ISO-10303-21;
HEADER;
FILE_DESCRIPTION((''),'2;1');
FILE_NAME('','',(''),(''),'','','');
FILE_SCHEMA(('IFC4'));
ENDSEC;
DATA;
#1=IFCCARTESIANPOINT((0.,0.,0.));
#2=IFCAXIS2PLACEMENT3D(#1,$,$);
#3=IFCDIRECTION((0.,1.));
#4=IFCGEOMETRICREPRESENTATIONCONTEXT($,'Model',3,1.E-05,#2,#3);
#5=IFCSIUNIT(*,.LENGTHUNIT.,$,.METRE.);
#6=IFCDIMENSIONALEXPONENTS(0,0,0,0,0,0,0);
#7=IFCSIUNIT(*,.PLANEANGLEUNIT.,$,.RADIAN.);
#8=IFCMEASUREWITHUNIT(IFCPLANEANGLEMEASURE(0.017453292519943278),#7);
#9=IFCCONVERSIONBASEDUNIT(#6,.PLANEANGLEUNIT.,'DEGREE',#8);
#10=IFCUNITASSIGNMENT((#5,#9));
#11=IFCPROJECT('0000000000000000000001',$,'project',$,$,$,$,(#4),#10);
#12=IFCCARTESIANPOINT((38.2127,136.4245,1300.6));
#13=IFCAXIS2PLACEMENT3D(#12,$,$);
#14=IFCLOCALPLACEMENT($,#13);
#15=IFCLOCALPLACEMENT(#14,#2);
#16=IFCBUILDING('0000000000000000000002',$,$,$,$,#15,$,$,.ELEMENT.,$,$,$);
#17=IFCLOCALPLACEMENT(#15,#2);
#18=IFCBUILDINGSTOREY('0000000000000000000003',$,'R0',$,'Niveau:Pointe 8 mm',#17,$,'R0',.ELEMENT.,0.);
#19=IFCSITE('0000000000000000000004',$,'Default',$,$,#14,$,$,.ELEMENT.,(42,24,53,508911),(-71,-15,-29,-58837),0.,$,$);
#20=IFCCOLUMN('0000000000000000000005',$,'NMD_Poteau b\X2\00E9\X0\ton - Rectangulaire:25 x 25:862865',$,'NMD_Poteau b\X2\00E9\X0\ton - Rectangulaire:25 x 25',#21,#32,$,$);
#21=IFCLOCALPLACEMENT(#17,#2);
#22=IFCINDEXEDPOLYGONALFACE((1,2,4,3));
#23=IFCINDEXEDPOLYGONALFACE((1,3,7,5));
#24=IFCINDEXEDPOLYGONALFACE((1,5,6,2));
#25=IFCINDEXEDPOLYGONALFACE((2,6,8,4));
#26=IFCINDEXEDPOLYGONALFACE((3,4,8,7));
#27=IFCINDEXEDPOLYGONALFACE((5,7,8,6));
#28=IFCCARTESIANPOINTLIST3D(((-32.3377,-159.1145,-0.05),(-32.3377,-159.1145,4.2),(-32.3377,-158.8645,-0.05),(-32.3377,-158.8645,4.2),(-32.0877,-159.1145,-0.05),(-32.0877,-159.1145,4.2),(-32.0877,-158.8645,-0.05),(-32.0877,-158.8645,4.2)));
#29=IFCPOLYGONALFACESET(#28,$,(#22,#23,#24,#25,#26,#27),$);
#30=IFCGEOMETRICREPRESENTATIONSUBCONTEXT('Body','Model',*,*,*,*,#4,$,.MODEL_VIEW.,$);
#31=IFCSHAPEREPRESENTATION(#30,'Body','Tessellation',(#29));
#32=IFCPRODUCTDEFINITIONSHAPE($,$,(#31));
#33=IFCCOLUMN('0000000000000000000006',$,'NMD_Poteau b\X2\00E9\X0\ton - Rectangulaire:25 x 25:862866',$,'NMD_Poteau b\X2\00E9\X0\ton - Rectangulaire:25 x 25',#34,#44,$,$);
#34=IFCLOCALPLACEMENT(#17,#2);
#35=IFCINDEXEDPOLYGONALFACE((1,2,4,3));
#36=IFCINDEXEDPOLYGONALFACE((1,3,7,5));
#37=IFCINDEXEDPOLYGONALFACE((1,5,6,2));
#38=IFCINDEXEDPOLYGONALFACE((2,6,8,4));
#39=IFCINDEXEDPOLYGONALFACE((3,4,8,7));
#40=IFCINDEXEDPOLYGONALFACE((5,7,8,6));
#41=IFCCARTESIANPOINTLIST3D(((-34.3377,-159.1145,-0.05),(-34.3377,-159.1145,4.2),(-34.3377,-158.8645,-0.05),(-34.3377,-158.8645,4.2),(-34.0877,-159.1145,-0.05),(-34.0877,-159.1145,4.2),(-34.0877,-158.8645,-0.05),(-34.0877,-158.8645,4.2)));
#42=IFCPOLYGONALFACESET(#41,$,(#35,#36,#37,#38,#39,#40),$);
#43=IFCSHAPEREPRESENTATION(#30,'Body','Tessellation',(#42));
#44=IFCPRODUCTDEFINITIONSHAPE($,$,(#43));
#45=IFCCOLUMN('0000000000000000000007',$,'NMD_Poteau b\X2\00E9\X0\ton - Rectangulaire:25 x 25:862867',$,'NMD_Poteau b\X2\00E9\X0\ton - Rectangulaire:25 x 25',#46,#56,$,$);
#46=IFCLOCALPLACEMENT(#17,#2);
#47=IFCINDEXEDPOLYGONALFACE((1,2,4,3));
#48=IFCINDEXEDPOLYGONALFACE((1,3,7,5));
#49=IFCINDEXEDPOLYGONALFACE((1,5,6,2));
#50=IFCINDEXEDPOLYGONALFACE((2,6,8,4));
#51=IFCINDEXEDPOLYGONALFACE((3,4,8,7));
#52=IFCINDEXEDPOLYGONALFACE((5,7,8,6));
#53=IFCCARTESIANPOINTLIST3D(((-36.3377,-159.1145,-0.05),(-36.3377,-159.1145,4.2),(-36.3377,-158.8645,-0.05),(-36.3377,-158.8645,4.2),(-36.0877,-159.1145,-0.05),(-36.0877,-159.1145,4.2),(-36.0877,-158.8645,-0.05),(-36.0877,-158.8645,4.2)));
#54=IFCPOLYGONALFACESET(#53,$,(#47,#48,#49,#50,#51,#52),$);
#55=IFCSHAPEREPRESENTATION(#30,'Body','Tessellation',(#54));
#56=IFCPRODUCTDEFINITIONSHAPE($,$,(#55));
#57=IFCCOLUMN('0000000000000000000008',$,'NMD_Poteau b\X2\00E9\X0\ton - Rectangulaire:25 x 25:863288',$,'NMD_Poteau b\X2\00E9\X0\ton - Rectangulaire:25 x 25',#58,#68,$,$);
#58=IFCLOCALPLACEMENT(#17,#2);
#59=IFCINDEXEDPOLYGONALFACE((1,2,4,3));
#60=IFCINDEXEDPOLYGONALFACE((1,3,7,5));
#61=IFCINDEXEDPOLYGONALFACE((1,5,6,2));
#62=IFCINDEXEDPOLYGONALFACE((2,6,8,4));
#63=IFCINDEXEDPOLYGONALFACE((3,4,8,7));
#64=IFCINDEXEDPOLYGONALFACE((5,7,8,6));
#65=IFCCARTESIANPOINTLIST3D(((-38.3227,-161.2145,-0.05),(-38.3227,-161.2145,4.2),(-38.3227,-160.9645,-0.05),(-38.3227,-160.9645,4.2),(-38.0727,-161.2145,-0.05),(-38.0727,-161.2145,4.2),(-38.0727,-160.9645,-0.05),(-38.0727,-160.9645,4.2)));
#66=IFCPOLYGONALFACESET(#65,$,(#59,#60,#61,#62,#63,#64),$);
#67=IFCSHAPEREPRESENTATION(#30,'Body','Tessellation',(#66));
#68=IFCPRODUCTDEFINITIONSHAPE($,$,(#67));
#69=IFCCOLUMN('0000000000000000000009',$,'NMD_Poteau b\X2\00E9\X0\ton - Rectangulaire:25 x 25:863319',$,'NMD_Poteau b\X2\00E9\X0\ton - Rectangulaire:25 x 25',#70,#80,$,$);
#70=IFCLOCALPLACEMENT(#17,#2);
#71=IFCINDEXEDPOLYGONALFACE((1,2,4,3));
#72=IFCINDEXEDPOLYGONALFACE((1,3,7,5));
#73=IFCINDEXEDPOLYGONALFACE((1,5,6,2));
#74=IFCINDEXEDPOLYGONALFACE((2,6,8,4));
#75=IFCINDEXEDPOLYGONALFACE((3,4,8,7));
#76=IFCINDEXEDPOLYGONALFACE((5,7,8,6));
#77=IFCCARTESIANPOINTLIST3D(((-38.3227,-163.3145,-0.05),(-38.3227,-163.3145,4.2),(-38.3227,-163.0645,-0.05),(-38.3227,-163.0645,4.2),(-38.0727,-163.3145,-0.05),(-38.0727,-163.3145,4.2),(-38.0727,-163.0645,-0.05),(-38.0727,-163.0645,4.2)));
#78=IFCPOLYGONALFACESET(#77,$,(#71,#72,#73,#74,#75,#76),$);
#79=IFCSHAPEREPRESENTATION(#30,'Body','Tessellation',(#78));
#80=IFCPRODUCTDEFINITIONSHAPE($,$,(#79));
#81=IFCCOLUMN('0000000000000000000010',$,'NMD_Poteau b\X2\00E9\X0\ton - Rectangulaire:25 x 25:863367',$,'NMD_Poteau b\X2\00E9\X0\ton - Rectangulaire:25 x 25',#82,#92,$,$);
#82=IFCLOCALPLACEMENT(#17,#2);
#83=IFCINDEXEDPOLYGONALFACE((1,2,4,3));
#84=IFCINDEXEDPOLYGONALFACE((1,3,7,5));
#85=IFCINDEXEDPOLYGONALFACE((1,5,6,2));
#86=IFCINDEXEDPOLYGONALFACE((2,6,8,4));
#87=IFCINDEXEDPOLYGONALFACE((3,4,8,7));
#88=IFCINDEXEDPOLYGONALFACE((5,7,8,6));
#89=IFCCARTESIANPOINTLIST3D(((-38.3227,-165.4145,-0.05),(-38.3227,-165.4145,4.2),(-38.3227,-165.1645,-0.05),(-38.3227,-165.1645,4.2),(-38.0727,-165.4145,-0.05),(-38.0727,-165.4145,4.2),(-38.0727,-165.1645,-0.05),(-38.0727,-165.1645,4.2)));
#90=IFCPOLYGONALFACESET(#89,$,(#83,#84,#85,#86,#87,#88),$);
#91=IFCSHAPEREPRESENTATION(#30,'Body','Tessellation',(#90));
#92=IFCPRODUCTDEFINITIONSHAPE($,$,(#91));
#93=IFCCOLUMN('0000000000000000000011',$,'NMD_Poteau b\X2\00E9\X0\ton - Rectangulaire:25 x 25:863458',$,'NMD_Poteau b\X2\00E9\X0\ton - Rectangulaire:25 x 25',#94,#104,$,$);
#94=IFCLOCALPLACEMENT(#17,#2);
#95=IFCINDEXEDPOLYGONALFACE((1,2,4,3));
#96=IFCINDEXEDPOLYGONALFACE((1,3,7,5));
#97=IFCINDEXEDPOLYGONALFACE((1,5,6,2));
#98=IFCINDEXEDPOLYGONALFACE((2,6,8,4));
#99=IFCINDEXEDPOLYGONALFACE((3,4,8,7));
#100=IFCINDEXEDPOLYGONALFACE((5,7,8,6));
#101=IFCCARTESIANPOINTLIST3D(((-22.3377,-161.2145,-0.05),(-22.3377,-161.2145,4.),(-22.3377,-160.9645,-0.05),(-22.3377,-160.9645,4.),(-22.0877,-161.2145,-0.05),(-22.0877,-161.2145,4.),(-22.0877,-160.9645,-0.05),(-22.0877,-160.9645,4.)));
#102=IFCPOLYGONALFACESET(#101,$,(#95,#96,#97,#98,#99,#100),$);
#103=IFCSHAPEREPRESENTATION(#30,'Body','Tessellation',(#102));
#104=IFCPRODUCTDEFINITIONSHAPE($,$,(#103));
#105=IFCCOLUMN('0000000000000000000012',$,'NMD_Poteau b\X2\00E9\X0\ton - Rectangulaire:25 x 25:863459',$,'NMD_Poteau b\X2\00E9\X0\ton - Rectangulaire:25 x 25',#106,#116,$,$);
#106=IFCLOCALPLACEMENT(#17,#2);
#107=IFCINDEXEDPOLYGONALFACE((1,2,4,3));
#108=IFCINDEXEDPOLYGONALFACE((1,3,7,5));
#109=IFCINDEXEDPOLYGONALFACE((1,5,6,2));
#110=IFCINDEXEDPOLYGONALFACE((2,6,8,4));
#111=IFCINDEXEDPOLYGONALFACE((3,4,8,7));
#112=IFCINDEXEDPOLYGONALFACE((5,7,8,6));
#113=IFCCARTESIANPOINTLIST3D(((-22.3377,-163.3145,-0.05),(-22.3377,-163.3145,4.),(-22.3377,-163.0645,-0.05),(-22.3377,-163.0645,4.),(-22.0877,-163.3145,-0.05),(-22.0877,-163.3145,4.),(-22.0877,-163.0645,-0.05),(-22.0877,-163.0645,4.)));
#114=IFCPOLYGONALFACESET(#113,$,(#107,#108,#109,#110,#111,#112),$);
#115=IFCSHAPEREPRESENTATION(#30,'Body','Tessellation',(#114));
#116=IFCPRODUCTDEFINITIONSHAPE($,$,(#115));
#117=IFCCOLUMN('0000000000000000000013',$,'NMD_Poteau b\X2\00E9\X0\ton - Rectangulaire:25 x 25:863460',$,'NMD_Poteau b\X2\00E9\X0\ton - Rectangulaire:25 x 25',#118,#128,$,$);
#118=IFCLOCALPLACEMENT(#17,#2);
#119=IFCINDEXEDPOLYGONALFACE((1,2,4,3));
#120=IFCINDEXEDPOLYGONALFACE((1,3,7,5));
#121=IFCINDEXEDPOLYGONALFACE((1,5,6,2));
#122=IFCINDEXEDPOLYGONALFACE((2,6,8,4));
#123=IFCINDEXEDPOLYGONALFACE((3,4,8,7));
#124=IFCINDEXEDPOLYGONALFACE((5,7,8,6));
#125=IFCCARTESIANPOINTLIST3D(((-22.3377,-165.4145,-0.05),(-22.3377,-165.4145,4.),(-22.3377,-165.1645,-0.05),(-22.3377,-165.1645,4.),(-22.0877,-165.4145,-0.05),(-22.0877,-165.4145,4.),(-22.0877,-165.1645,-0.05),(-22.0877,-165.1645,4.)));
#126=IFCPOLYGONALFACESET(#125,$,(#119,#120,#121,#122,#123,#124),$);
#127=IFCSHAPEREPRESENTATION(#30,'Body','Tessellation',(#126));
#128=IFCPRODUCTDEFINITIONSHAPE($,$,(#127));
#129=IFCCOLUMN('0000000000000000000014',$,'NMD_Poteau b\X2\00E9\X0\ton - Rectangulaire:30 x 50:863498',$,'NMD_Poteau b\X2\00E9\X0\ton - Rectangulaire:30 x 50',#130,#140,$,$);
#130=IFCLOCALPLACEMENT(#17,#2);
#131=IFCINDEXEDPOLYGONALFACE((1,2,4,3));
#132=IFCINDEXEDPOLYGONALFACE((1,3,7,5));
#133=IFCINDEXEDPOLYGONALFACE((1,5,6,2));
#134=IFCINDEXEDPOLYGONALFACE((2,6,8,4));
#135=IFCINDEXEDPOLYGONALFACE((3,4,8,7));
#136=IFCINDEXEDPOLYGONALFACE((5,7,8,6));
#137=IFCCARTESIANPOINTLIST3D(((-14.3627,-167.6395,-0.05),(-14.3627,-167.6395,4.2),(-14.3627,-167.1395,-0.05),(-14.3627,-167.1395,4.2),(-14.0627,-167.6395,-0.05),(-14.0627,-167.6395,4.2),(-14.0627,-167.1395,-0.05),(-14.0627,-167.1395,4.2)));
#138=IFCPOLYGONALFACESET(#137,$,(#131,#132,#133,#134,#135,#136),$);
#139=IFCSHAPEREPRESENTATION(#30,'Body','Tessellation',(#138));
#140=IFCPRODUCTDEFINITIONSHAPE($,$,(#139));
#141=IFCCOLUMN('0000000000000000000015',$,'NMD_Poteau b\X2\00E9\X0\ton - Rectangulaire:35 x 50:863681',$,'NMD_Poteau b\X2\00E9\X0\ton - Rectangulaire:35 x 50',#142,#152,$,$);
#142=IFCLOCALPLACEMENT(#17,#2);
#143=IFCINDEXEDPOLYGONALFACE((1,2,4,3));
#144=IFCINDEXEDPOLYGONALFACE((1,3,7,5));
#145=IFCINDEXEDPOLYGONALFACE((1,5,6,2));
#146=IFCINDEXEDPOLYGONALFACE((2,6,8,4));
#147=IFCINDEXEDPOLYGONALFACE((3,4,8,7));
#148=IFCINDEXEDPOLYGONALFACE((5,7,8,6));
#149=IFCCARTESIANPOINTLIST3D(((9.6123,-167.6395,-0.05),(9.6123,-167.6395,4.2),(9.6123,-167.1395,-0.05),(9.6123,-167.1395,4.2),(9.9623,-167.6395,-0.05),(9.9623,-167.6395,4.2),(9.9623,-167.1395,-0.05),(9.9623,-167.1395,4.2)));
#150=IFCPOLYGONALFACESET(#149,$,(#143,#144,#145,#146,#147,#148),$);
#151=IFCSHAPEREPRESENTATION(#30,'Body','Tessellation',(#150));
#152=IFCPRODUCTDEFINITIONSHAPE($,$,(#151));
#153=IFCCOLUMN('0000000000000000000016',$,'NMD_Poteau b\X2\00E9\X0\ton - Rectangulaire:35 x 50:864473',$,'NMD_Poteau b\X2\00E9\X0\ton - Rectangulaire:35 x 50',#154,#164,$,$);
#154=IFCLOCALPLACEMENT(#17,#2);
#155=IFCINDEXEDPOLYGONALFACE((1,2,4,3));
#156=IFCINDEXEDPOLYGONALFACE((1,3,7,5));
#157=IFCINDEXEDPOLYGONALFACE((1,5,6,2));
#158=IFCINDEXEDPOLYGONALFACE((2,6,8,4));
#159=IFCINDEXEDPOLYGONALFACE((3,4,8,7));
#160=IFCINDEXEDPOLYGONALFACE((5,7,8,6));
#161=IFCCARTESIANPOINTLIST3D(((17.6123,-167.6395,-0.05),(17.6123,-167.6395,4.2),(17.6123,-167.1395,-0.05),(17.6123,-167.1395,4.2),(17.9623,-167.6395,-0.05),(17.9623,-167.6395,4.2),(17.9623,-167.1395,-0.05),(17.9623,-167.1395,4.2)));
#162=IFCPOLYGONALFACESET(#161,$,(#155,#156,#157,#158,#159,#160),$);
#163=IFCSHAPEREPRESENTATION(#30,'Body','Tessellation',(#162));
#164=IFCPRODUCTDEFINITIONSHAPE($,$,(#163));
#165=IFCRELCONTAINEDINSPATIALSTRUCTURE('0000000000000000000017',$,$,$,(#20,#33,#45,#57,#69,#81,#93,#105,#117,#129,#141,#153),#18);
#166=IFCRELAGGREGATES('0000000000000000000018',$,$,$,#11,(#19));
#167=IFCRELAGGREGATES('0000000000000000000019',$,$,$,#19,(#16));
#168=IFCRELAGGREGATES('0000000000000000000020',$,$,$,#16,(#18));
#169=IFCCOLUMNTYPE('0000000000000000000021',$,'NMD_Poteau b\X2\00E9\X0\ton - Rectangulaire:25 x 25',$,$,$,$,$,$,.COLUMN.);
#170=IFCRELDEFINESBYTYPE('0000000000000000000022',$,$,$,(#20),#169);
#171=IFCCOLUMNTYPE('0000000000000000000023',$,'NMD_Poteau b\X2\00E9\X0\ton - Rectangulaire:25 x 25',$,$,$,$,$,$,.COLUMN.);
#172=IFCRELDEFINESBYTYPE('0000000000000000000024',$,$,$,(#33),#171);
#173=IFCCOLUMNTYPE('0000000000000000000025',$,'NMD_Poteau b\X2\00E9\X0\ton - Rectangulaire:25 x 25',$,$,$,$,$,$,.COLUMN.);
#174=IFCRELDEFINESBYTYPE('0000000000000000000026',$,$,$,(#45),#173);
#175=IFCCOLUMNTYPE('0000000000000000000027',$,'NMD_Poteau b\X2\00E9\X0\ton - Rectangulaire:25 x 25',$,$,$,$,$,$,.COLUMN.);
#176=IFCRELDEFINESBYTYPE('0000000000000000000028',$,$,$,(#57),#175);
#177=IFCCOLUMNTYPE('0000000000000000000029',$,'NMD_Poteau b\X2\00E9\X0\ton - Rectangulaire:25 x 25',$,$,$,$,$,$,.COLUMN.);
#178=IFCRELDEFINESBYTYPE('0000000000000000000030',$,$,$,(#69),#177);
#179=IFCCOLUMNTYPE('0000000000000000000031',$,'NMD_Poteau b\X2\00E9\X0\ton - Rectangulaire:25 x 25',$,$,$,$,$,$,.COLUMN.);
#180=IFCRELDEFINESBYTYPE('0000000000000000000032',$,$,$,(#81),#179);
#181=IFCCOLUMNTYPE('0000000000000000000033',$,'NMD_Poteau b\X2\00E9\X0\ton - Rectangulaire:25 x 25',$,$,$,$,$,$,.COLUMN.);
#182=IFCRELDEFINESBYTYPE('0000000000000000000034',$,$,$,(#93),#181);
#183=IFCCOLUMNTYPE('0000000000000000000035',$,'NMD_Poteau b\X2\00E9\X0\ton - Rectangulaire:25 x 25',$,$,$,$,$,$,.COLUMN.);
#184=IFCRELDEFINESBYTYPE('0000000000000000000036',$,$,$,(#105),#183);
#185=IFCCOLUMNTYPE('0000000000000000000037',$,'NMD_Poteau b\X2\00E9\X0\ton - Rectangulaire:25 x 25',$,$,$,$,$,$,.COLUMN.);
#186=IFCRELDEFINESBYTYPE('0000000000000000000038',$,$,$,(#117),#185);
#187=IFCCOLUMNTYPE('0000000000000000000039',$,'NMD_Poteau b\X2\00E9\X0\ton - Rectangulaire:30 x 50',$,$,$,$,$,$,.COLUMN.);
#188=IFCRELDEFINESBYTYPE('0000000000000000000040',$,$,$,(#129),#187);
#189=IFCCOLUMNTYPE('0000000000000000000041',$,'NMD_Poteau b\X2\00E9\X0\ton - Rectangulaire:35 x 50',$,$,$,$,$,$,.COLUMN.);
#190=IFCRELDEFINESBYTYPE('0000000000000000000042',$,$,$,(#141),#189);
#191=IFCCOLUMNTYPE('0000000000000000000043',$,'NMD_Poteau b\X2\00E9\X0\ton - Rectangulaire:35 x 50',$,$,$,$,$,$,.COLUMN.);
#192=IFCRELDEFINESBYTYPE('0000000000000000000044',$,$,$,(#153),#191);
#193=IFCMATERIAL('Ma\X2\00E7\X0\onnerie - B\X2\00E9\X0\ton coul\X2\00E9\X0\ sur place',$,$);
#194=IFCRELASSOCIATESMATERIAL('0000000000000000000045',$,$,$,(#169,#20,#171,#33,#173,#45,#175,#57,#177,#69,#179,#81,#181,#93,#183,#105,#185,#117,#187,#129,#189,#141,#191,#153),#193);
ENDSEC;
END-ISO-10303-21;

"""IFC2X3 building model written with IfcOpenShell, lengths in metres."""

from ifc_helpers import new_model, entity, si_unit, converted_unit, direction, frame, frame_2d, origin, place, context, subcontext, project, spatial, rectangle, extrude, source, transform, mapped, material, type_object, type_shapes, element, save


model = new_model("IFC2X3")

# Units and contexts
model_context = context("Model", 3, precision=1e-05, world=origin(), true_north=direction((0.0, 1.0)))
body_context = subcontext(model_context, "Body", "Model", "MODEL_VIEW")
ifc_project = project(units=[si_unit("LENGTHUNIT", "METRE"), converted_unit("PLANEANGLEUNIT", "DEGREE", entity("IfcPlaneAngleMeasure", 0.017453292519943278), si_unit("PLANEANGLEUNIT", "RADIAN"), dimensions=[0, 0, 0, 0, 0, 0, 0])], contexts=[model_context])

# Site, building, storey
site_placement = place(None, frame((38.2127, 136.4245, 1300.6)))
site = spatial("IfcSite", under=ifc_project, at=site_placement, Name="Default", CompositionType="ELEMENT", RefLatitude=(42, 24, 53, 508911), RefLongitude=(-71, -15, -29, -58837), RefElevation=0.0)
building_placement = place(site_placement, origin())
building = spatial("IfcBuilding", under=site, at=building_placement, CompositionType="ELEMENT")
storey_placement = place(building_placement, origin())
storey = spatial("IfcBuildingStorey", under=building, at=storey_placement, Name="R0", ObjectType="Niveau:Pointe 8 mm", LongName="R0", CompositionType="ELEMENT", Elevation=0.0)

# Columns
ifc_material = material(Name="Maçonnerie - Béton coulé sur place")
column_type_1 = type_object("IfcColumnType", Name="NMD_Poteau béton - Rectangulaire:25 x 25", PredefinedType="COLUMN", material=ifc_material)
shared_shape_1 = source(origin(), body_context, "Body", "SweptSolid", [
    extrude(rectangle(XDim=0.25, YDim=0.25, at=frame_2d((0.0, 0.0), x_axis=(1.0, 0.0))), frame((-32.2127, -158.9895, -0.05), z_axis=(0.0, 0.0, 1.0), x_axis=(-1.0, 0.0, 0.0)), (0.0, 0.0, 1.0), 4.25),
])
type_shapes(column_type_1, [shared_shape_1])
column_1_placement = place(storey_placement, origin())
element("IfcColumn", 1, at=column_1_placement, inside=storey, type_object=column_type_1, material=ifc_material, Name="NMD_Poteau béton - Rectangulaire:25 x 25:862865", ObjectType="NMD_Poteau béton - Rectangulaire:25 x 25", context=body_context, shape_type="MappedRepresentation", body=[
    mapped(shared_shape_1, transform((0.0, 0.0, 0.0), scale=1.0)),
])
column_type_2 = type_object("IfcColumnType", Name="NMD_Poteau béton - Rectangulaire:25 x 25", PredefinedType="COLUMN", material=ifc_material)
shared_shape_2 = source(origin(), body_context, "Body", "SweptSolid", [
    extrude(rectangle(XDim=0.25, YDim=0.25, at=frame_2d((0.0, 0.0), x_axis=(1.0, 0.0))), frame((-34.2127, -158.9895, -0.05), z_axis=(0.0, 0.0, 1.0), x_axis=(-1.0, 0.0, 0.0)), (0.0, 0.0, 1.0), 4.25),
])
type_shapes(column_type_2, [shared_shape_2])
column_2_placement = place(storey_placement, origin())
element("IfcColumn", 2, at=column_2_placement, inside=storey, type_object=column_type_2, material=ifc_material, Name="NMD_Poteau béton - Rectangulaire:25 x 25:862866", ObjectType="NMD_Poteau béton - Rectangulaire:25 x 25", context=body_context, shape_type="MappedRepresentation", body=[
    mapped(shared_shape_2, transform((0.0, 0.0, 0.0), scale=1.0)),
])
column_type_3 = type_object("IfcColumnType", Name="NMD_Poteau béton - Rectangulaire:25 x 25", PredefinedType="COLUMN", material=ifc_material)
shared_shape_3 = source(origin(), body_context, "Body", "SweptSolid", [
    extrude(rectangle(XDim=0.25, YDim=0.25, at=frame_2d((0.0, 0.0), x_axis=(1.0, 0.0))), frame((-36.2127, -158.9895, -0.05), z_axis=(0.0, 0.0, 1.0), x_axis=(-1.0, 0.0, 0.0)), (0.0, 0.0, 1.0), 4.25),
])
type_shapes(column_type_3, [shared_shape_3])
column_3_placement = place(storey_placement, origin())
element("IfcColumn", 3, at=column_3_placement, inside=storey, type_object=column_type_3, material=ifc_material, Name="NMD_Poteau béton - Rectangulaire:25 x 25:862867", ObjectType="NMD_Poteau béton - Rectangulaire:25 x 25", context=body_context, shape_type="MappedRepresentation", body=[
    mapped(shared_shape_3, transform((0.0, 0.0, 0.0), scale=1.0)),
])
column_type_4 = type_object("IfcColumnType", Name="NMD_Poteau béton - Rectangulaire:25 x 25", PredefinedType="COLUMN", material=ifc_material)
shared_shape_4 = source(origin(), body_context, "Body", "SweptSolid", [
    extrude(rectangle(XDim=0.25, YDim=0.25, at=frame_2d((0.0, 0.0), x_axis=(1.0, 0.0))), frame((-38.1977, -161.0895, -0.05), z_axis=(0.0, 0.0, 1.0), x_axis=(0.0, 1.0, 0.0)), (0.0, 0.0, 1.0), 4.25),
])
type_shapes(column_type_4, [shared_shape_4])
column_4_placement = place(storey_placement, origin())
element("IfcColumn", 4, at=column_4_placement, inside=storey, type_object=column_type_4, material=ifc_material, Name="NMD_Poteau béton - Rectangulaire:25 x 25:863288", ObjectType="NMD_Poteau béton - Rectangulaire:25 x 25", context=body_context, shape_type="MappedRepresentation", body=[
    mapped(shared_shape_4, transform((0.0, 0.0, 0.0), scale=1.0)),
])
column_type_5 = type_object("IfcColumnType", Name="NMD_Poteau béton - Rectangulaire:25 x 25", PredefinedType="COLUMN", material=ifc_material)
shared_shape_5 = source(origin(), body_context, "Body", "SweptSolid", [
    extrude(rectangle(XDim=0.25, YDim=0.25, at=frame_2d((0.0, 0.0), x_axis=(1.0, 0.0))), frame((-38.1977, -163.1895, -0.05), z_axis=(0.0, 0.0, 1.0), x_axis=(0.0, 1.0, 0.0)), (0.0, 0.0, 1.0), 4.25),
])
type_shapes(column_type_5, [shared_shape_5])
column_5_placement = place(storey_placement, origin())
element("IfcColumn", 5, at=column_5_placement, inside=storey, type_object=column_type_5, material=ifc_material, Name="NMD_Poteau béton - Rectangulaire:25 x 25:863319", ObjectType="NMD_Poteau béton - Rectangulaire:25 x 25", context=body_context, shape_type="MappedRepresentation", body=[
    mapped(shared_shape_5, transform((0.0, 0.0, 0.0), scale=1.0)),
])
column_type_6 = type_object("IfcColumnType", Name="NMD_Poteau béton - Rectangulaire:25 x 25", PredefinedType="COLUMN", material=ifc_material)
shared_shape_6 = source(origin(), body_context, "Body", "SweptSolid", [
    extrude(rectangle(XDim=0.25, YDim=0.25, at=frame_2d((0.0, 0.0), x_axis=(1.0, 0.0))), frame((-38.1977, -165.2895, -0.05), z_axis=(0.0, 0.0, 1.0), x_axis=(0.0, 1.0, 0.0)), (0.0, 0.0, 1.0), 4.25),
])
type_shapes(column_type_6, [shared_shape_6])
column_6_placement = place(storey_placement, origin())
element("IfcColumn", 6, at=column_6_placement, inside=storey, type_object=column_type_6, material=ifc_material, Name="NMD_Poteau béton - Rectangulaire:25 x 25:863367", ObjectType="NMD_Poteau béton - Rectangulaire:25 x 25", context=body_context, shape_type="MappedRepresentation", body=[
    mapped(shared_shape_6, transform((0.0, 0.0, 0.0), scale=1.0)),
])
column_type_7 = type_object("IfcColumnType", Name="NMD_Poteau béton - Rectangulaire:25 x 25", PredefinedType="COLUMN", material=ifc_material)
shared_shape_7 = source(origin(), body_context, "Body", "SweptSolid", [
    extrude(rectangle(XDim=0.25, YDim=0.25, at=frame_2d((0.0, 0.0), x_axis=(1.0, 0.0))), frame((-22.2127, -161.0895, -0.05), z_axis=(0.0, 0.0, 1.0), x_axis=(0.0, 1.0, 0.0)), (0.0, 0.0, 1.0), 4.05),
])
type_shapes(column_type_7, [shared_shape_7])
column_7_placement = place(storey_placement, origin())
element("IfcColumn", 7, at=column_7_placement, inside=storey, type_object=column_type_7, material=ifc_material, Name="NMD_Poteau béton - Rectangulaire:25 x 25:863458", ObjectType="NMD_Poteau béton - Rectangulaire:25 x 25", context=body_context, shape_type="MappedRepresentation", body=[
    mapped(shared_shape_7, transform((0.0, 0.0, 0.0), scale=1.0)),
])
column_type_8 = type_object("IfcColumnType", Name="NMD_Poteau béton - Rectangulaire:25 x 25", PredefinedType="COLUMN", material=ifc_material)
shared_shape_8 = source(origin(), body_context, "Body", "SweptSolid", [
    extrude(rectangle(XDim=0.25, YDim=0.25, at=frame_2d((0.0, 0.0), x_axis=(1.0, 0.0))), frame((-22.2127, -163.1895, -0.05), z_axis=(0.0, 0.0, 1.0), x_axis=(0.0, 1.0, 0.0)), (0.0, 0.0, 1.0), 4.05),
])
type_shapes(column_type_8, [shared_shape_8])
column_8_placement = place(storey_placement, origin())
element("IfcColumn", 8, at=column_8_placement, inside=storey, type_object=column_type_8, material=ifc_material, Name="NMD_Poteau béton - Rectangulaire:25 x 25:863459", ObjectType="NMD_Poteau béton - Rectangulaire:25 x 25", context=body_context, shape_type="MappedRepresentation", body=[
    mapped(shared_shape_8, transform((0.0, 0.0, 0.0), scale=1.0)),
])
column_type_9 = type_object("IfcColumnType", Name="NMD_Poteau béton - Rectangulaire:25 x 25", PredefinedType="COLUMN", material=ifc_material)
shared_shape_9 = source(origin(), body_context, "Body", "SweptSolid", [
    extrude(rectangle(XDim=0.25, YDim=0.25, at=frame_2d((0.0, 0.0), x_axis=(1.0, 0.0))), frame((-22.2127, -165.2895, -0.05), z_axis=(0.0, 0.0, 1.0), x_axis=(0.0, 1.0, 0.0)), (0.0, 0.0, 1.0), 4.05),
])
type_shapes(column_type_9, [shared_shape_9])
column_9_placement = place(storey_placement, origin())
element("IfcColumn", 9, at=column_9_placement, inside=storey, type_object=column_type_9, material=ifc_material, Name="NMD_Poteau béton - Rectangulaire:25 x 25:863460", ObjectType="NMD_Poteau béton - Rectangulaire:25 x 25", context=body_context, shape_type="MappedRepresentation", body=[
    mapped(shared_shape_9, transform((0.0, 0.0, 0.0), scale=1.0)),
])
column_type_10 = type_object("IfcColumnType", Name="NMD_Poteau béton - Rectangulaire:30 x 50", PredefinedType="COLUMN", material=ifc_material)
shared_shape_10 = source(origin(), body_context, "Body", "SweptSolid", [
    extrude(rectangle(XDim=0.3, YDim=0.5, at=frame_2d((0.0, 0.0), x_axis=(1.0, 0.0))), frame((-14.2127, -167.3895, -0.05), z_axis=(0.0, 0.0, 1.0), x_axis=(-1.0, 0.0, 0.0)), (0.0, 0.0, 1.0), 4.25),
])
type_shapes(column_type_10, [shared_shape_10])
column_10_placement = place(storey_placement, origin())
element("IfcColumn", 10, at=column_10_placement, inside=storey, type_object=column_type_10, material=ifc_material, Name="NMD_Poteau béton - Rectangulaire:30 x 50:863498", ObjectType="NMD_Poteau béton - Rectangulaire:30 x 50", context=body_context, shape_type="MappedRepresentation", body=[
    mapped(shared_shape_10, transform((0.0, 0.0, 0.0), scale=1.0)),
])
column_type_11 = type_object("IfcColumnType", Name="NMD_Poteau béton - Rectangulaire:35 x 50", PredefinedType="COLUMN", material=ifc_material)
shared_shape_11 = source(origin(), body_context, "Body", "SweptSolid", [
    extrude(rectangle(XDim=0.35, YDim=0.5, at=frame_2d((0.0, 0.0), x_axis=(1.0, 0.0))), frame((9.7873, -167.3895, -0.05), z_axis=(0.0, 0.0, 1.0), x_axis=(-1.0, 0.0, 0.0)), (0.0, 0.0, 1.0), 4.25),
])
type_shapes(column_type_11, [shared_shape_11])
column_11_placement = place(storey_placement, origin())
element("IfcColumn", 11, at=column_11_placement, inside=storey, type_object=column_type_11, material=ifc_material, Name="NMD_Poteau béton - Rectangulaire:35 x 50:863681", ObjectType="NMD_Poteau béton - Rectangulaire:35 x 50", context=body_context, shape_type="MappedRepresentation", body=[
    mapped(shared_shape_11, transform((0.0, 0.0, 0.0), scale=1.0)),
])
column_type_12 = type_object("IfcColumnType", Name="NMD_Poteau béton - Rectangulaire:35 x 50", PredefinedType="COLUMN", material=ifc_material)
shared_shape_12 = source(origin(), body_context, "Body", "SweptSolid", [
    extrude(rectangle(XDim=0.35, YDim=0.5, at=frame_2d((0.0, 0.0), x_axis=(1.0, 0.0))), frame((17.7873, -167.3895, -0.05), z_axis=(0.0, 0.0, 1.0), x_axis=(-1.0, 0.0, 0.0)), (0.0, 0.0, 1.0), 4.25),
])
type_shapes(column_type_12, [shared_shape_12])
column_12_placement = place(storey_placement, origin())
element("IfcColumn", 12, at=column_12_placement, inside=storey, type_object=column_type_12, material=ifc_material, Name="NMD_Poteau béton - Rectangulaire:35 x 50:864473", ObjectType="NMD_Poteau béton - Rectangulaire:35 x 50", context=body_context, shape_type="MappedRepresentation", body=[
    mapped(shared_shape_12, transform((0.0, 0.0, 0.0), scale=1.0)),
])

save(model, "model.ifc")
